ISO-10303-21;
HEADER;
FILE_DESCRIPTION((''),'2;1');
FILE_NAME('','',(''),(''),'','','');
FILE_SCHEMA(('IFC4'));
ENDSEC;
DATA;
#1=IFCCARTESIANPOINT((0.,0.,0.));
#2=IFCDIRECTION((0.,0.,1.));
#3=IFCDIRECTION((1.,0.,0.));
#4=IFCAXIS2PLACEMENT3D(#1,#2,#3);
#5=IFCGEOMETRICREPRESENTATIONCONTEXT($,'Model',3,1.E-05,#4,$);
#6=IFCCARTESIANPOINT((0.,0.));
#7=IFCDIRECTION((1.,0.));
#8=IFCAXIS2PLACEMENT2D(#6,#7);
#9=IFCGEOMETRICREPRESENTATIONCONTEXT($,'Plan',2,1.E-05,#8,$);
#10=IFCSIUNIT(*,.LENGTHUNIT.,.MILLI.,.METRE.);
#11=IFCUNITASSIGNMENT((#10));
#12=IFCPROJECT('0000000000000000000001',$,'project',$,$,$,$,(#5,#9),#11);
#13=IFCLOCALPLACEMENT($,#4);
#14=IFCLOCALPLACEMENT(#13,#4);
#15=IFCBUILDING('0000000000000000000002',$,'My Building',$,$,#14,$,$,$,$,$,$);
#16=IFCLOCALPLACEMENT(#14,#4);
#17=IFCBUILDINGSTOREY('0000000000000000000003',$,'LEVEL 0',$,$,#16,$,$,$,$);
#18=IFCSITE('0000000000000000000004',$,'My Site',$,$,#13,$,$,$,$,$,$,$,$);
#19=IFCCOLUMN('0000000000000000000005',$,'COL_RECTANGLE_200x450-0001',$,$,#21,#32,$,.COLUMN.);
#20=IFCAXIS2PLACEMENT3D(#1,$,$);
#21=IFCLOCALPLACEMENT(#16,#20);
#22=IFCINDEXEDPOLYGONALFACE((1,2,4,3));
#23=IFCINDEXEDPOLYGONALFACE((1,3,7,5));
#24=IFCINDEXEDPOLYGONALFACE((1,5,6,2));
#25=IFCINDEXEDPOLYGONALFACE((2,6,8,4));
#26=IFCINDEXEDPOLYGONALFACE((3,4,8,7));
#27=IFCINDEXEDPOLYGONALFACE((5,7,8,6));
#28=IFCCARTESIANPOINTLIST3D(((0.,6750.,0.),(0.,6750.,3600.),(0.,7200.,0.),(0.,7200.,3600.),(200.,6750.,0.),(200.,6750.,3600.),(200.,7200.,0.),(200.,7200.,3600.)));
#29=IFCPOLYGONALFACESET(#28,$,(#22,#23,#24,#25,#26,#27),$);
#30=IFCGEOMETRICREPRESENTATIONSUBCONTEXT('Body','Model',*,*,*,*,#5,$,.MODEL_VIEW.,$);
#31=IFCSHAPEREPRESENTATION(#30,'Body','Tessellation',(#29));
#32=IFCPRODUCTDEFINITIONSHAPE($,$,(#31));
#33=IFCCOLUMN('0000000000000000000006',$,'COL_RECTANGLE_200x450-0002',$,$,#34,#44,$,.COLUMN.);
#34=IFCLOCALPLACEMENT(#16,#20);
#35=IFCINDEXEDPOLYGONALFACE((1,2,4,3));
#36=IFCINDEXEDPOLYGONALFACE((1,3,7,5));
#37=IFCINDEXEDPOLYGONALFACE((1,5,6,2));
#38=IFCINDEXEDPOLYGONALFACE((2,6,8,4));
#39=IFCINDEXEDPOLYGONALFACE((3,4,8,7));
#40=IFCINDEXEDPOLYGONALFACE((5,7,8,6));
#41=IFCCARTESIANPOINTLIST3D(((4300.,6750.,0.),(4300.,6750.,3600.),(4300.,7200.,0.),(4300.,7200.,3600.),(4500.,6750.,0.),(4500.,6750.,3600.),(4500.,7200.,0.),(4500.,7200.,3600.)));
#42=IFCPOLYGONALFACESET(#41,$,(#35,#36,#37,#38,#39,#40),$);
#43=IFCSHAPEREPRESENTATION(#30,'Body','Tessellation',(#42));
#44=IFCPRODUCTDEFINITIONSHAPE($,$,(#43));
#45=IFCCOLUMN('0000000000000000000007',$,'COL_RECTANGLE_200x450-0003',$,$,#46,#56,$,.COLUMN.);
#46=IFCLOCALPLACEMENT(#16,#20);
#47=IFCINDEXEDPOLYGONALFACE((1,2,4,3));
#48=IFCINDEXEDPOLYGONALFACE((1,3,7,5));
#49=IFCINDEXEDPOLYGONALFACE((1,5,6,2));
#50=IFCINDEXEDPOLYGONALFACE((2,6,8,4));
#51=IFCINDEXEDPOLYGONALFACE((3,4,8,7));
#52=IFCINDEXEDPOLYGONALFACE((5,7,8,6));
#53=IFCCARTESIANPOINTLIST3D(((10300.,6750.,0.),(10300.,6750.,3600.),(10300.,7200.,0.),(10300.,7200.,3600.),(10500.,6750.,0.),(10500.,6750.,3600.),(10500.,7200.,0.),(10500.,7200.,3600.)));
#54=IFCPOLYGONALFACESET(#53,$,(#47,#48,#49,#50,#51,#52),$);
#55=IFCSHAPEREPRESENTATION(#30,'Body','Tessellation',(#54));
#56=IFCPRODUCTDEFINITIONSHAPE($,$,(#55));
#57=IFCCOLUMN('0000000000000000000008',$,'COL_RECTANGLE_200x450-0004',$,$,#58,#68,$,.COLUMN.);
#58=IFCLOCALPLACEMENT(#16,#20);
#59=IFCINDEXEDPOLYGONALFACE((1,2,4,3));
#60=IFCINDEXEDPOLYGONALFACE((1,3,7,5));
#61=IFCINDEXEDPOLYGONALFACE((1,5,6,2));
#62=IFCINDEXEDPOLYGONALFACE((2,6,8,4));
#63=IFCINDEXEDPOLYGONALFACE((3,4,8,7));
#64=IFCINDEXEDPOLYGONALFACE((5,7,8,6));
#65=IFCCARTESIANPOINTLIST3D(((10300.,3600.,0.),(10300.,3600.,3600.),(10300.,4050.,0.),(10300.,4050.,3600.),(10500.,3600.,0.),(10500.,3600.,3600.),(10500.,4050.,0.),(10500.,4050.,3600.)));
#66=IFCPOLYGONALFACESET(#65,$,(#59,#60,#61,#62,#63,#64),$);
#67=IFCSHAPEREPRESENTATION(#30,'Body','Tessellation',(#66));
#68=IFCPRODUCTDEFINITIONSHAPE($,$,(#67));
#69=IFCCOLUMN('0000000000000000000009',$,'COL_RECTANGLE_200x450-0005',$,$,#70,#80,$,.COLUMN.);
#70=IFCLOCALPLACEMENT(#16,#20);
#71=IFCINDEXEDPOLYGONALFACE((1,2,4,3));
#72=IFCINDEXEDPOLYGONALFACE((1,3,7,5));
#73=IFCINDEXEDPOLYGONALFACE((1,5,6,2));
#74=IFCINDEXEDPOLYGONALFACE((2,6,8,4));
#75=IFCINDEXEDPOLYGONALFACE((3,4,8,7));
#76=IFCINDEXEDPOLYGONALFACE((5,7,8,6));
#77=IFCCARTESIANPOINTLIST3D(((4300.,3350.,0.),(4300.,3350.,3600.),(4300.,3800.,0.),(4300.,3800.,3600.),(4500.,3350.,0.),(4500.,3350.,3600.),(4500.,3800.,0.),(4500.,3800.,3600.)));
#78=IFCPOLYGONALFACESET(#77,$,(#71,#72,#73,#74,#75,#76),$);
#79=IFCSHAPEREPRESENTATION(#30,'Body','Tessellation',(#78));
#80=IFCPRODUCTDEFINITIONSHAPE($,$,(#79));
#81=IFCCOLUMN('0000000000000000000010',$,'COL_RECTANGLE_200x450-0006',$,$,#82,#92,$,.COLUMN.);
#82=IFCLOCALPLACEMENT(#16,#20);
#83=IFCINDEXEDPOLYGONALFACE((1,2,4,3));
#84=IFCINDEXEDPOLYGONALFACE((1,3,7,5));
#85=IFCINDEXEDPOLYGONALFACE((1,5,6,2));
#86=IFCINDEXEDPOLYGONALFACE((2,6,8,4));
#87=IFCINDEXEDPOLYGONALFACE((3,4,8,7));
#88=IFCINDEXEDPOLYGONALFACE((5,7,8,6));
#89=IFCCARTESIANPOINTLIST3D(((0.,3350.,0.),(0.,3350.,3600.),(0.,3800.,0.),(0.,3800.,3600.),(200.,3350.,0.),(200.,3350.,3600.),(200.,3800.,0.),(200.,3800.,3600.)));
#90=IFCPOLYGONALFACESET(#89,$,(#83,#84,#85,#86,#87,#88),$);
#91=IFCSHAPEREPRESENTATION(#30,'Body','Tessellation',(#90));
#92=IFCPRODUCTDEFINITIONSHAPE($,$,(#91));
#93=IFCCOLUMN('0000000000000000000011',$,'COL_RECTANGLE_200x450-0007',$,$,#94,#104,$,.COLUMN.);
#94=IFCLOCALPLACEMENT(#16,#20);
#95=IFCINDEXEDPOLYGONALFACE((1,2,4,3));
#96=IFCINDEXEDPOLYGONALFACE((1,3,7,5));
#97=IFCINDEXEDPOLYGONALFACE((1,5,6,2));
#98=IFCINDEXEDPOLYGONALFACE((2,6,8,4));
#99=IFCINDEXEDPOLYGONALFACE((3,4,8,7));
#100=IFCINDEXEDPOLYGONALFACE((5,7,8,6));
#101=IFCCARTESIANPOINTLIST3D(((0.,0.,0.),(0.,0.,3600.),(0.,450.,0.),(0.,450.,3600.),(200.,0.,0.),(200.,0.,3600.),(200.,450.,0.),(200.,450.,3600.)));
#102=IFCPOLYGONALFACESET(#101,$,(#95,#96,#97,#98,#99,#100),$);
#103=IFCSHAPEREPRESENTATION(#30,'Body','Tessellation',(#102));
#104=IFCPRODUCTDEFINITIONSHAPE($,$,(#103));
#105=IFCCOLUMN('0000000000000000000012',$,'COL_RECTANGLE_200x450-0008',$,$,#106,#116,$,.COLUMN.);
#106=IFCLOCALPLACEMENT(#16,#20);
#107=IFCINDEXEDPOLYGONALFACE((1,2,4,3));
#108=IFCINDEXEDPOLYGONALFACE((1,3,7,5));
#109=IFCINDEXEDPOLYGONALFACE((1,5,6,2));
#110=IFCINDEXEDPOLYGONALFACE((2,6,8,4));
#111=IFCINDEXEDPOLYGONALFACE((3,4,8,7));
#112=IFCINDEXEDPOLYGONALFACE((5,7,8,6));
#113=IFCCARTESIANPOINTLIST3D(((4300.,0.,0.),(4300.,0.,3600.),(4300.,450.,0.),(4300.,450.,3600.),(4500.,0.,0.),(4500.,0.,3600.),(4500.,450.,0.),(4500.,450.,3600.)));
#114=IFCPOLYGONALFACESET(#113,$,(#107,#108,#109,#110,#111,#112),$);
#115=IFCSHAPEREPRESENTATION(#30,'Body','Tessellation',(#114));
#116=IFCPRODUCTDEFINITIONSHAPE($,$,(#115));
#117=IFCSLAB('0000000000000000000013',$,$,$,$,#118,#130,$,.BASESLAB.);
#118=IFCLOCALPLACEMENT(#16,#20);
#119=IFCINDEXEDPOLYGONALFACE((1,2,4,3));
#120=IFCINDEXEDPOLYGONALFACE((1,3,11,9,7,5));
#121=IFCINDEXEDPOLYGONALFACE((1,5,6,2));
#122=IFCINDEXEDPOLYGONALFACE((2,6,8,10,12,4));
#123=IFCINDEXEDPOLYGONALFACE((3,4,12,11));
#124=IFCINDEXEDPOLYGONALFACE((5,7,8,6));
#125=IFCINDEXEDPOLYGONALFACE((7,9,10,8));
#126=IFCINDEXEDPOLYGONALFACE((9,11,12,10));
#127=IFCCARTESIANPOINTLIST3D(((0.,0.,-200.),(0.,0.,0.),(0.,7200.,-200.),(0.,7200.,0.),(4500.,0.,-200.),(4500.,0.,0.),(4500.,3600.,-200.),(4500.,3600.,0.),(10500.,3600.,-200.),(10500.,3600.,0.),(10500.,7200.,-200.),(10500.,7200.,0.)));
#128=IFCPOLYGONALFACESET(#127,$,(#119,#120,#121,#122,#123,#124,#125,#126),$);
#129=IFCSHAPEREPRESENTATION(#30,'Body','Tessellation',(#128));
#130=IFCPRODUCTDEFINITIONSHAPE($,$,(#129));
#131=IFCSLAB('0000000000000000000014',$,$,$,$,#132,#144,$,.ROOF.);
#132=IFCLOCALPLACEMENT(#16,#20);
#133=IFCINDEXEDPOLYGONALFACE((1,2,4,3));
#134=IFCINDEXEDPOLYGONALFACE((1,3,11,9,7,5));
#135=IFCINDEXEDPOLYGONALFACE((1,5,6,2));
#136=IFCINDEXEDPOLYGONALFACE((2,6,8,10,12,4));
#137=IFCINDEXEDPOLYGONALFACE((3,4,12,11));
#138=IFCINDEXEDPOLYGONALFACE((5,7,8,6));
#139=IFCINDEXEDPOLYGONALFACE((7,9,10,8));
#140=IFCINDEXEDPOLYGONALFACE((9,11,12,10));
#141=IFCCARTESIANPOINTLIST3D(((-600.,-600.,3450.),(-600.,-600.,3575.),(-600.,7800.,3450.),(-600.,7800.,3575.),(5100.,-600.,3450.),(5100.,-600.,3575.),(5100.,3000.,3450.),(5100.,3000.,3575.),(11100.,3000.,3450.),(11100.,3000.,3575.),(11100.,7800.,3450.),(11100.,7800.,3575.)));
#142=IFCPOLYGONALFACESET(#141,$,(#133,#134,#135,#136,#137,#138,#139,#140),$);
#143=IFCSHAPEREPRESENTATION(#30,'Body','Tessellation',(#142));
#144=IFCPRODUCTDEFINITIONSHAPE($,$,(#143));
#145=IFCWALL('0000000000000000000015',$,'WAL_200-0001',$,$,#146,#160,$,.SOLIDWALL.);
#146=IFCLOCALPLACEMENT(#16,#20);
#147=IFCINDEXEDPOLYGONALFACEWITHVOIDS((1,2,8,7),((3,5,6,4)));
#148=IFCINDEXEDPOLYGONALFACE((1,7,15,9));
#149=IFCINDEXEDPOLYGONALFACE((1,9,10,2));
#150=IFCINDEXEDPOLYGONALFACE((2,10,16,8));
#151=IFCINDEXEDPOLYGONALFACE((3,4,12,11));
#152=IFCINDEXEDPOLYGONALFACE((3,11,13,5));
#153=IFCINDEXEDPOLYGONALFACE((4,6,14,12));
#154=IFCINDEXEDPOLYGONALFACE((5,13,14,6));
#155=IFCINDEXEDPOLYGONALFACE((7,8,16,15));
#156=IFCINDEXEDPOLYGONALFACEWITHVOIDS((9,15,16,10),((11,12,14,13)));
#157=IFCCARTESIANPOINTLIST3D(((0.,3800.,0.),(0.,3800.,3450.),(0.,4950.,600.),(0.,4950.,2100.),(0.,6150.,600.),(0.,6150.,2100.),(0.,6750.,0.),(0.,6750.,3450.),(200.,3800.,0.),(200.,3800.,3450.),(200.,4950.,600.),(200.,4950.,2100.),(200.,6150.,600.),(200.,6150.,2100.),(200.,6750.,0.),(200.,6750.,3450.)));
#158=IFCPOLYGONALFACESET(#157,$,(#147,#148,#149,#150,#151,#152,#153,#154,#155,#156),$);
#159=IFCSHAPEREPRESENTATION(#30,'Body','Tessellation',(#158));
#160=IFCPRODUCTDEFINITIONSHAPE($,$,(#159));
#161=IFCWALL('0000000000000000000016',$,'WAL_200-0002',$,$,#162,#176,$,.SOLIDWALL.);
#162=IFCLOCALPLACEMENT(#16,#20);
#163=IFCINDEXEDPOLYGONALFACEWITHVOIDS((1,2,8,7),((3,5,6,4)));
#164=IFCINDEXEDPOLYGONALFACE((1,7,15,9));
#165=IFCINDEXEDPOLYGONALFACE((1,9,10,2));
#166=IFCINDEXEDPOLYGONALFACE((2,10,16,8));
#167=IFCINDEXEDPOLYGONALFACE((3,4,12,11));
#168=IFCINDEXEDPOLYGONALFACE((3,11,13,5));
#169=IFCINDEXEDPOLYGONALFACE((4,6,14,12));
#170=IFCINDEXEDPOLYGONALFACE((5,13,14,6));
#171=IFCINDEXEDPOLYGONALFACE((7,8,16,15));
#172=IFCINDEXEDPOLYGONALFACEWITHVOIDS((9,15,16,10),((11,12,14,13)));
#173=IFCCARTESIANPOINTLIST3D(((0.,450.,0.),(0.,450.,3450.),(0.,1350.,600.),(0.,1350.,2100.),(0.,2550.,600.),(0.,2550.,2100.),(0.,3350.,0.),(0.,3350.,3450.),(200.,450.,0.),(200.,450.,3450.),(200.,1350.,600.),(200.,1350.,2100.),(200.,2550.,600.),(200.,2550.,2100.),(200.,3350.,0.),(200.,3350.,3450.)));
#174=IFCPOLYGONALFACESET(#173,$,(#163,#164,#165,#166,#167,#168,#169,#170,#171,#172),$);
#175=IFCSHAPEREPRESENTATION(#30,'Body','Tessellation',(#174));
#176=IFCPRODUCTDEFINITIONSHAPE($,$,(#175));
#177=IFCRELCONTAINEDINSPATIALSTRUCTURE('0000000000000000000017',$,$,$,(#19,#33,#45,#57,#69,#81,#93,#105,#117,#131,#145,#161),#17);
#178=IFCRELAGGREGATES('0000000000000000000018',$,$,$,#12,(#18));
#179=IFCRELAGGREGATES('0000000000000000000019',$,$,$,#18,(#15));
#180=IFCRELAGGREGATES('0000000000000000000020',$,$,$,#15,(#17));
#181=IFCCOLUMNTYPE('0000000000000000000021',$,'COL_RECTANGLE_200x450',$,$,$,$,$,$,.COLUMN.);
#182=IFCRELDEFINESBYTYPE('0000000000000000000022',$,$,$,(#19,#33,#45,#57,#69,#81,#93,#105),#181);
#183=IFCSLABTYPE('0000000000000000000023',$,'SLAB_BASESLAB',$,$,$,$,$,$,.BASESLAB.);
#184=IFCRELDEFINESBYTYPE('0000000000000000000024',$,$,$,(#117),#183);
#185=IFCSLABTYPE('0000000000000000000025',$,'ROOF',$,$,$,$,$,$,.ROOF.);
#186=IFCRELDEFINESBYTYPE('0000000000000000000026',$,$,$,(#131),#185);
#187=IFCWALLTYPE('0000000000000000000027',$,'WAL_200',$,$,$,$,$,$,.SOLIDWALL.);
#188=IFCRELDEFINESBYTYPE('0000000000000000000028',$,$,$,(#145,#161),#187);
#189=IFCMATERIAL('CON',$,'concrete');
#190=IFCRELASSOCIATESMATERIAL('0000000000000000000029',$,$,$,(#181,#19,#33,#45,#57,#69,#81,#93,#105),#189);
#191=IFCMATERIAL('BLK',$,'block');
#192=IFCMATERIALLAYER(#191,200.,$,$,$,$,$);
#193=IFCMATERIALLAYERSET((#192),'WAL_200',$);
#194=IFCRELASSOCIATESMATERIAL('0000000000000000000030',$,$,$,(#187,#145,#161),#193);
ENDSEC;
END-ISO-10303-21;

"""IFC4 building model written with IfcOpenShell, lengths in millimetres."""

from ifc_helpers import new_model, si_unit, frame, origin_with_axes, origin_2d_with_axis, place, context, subcontext, project, spatial, indexed_curve, rectangle, outline, extrude, material, layer, layer_set, layer_usage, material_profile, profile_set, profile_usage, type_object, element, save


model = new_model("IFC4")

# Units and contexts
model_context = context("Model", 3, precision=1e-05, world=origin_with_axes())
plan_context = context("Plan", 2, precision=1e-05, world=origin_2d_with_axis())
body_context = subcontext(model_context, "Body", "Model", "MODEL_VIEW")
ifc_project = project(units=[si_unit("LENGTHUNIT", "METRE", prefix="MILLI")], contexts=[model_context, plan_context])

# Site, building, storey
site_placement = place(None, origin_with_axes())
site = spatial("IfcSite", under=ifc_project, at=site_placement, Name="My Site")
building_placement = place(site_placement, origin_with_axes())
building = spatial("IfcBuilding", under=site, at=building_placement, Name="My Building")
storey_placement = place(building_placement, origin_with_axes())
storey = spatial("IfcBuildingStorey", under=building, at=storey_placement, Name="LEVEL 0")

# Columns
ifc_material_1 = material(Name="CON", Category="concrete")
ifc_material_profile = material_profile(ifc_material_1, rectangle(XDim=200.0, YDim=450.0))
ifc_profile_set = profile_set([ifc_material_profile], Name="COL_RECTANGLE_200x450")
ifc_profile_usage_1 = profile_usage(ifc_profile_set)
column_type = type_object("IfcColumnType", Name="COL_RECTANGLE_200x450", PredefinedType="COLUMN", material=ifc_profile_set)
column_1_placement = place(storey_placement, frame((100.0, 6975.0, 0.0), z_axis=(0.0, 0.0, 1.0), x_axis=(1.0, 0.0, 0.0)))
element("IfcColumn", 1, at=column_1_placement, inside=storey, type_object=column_type, material=ifc_profile_usage_1, Name="COL_RECTANGLE_200x450-0001", PredefinedType="COLUMN", context=body_context, shape_type="SweptSolid", body=[
    extrude(rectangle(XDim=200.0, YDim=450.0), origin_with_axes(), (0.0, 0.0, 1.0), 3600.0),
])
ifc_profile_usage_2 = profile_usage(ifc_profile_set)
column_2_placement = place(storey_placement, frame((4400.0, 6975.0, 0.0), z_axis=(0.0, 0.0, 1.0), x_axis=(1.0, 0.0, 0.0)))
element("IfcColumn", 2, at=column_2_placement, inside=storey, type_object=column_type, material=ifc_profile_usage_2, Name="COL_RECTANGLE_200x450-0002", PredefinedType="COLUMN", context=body_context, shape_type="SweptSolid", body=[
    extrude(rectangle(XDim=200.0, YDim=450.0), origin_with_axes(), (0.0, 0.0, 1.0), 3600.0),
])
ifc_profile_usage_3 = profile_usage(ifc_profile_set)
column_3_placement = place(storey_placement, frame((10400.0, 6975.0, 0.0), z_axis=(0.0, 0.0, 1.0), x_axis=(1.0, 0.0, 0.0)))
element("IfcColumn", 3, at=column_3_placement, inside=storey, type_object=column_type, material=ifc_profile_usage_3, Name="COL_RECTANGLE_200x450-0003", PredefinedType="COLUMN", context=body_context, shape_type="SweptSolid", body=[
    extrude(rectangle(XDim=200.0, YDim=450.0), origin_with_axes(), (0.0, 0.0, 1.0), 3600.0),
])
ifc_profile_usage_4 = profile_usage(ifc_profile_set)
column_4_placement = place(storey_placement, frame((10400.0, 3825.0, 0.0), z_axis=(0.0, 0.0, 1.0), x_axis=(1.0, 0.0, 0.0)))
element("IfcColumn", 4, at=column_4_placement, inside=storey, type_object=column_type, material=ifc_profile_usage_4, Name="COL_RECTANGLE_200x450-0004", PredefinedType="COLUMN", context=body_context, shape_type="SweptSolid", body=[
    extrude(rectangle(XDim=200.0, YDim=450.0), origin_with_axes(), (0.0, 0.0, 1.0), 3600.0),
])
ifc_profile_usage_5 = profile_usage(ifc_profile_set)
column_5_placement = place(storey_placement, frame((4400.0, 3575.0, 0.0), z_axis=(0.0, 0.0, 1.0), x_axis=(1.0, 0.0, 0.0)))
element("IfcColumn", 5, at=column_5_placement, inside=storey, type_object=column_type, material=ifc_profile_usage_5, Name="COL_RECTANGLE_200x450-0005", PredefinedType="COLUMN", context=body_context, shape_type="SweptSolid", body=[
    extrude(rectangle(XDim=200.0, YDim=450.0), origin_with_axes(), (0.0, 0.0, 1.0), 3600.0),
])
ifc_profile_usage_6 = profile_usage(ifc_profile_set)
column_6_placement = place(storey_placement, frame((100.0, 3575.0, 0.0), z_axis=(0.0, 0.0, 1.0), x_axis=(1.0, 0.0, 0.0)))
element("IfcColumn", 6, at=column_6_placement, inside=storey, type_object=column_type, material=ifc_profile_usage_6, Name="COL_RECTANGLE_200x450-0006", PredefinedType="COLUMN", context=body_context, shape_type="SweptSolid", body=[
    extrude(rectangle(XDim=200.0, YDim=450.0), origin_with_axes(), (0.0, 0.0, 1.0), 3600.0),
])
ifc_profile_usage_7 = profile_usage(ifc_profile_set)
column_7_placement = place(storey_placement, frame((100.0, 225.0, 0.0), z_axis=(0.0, 0.0, 1.0), x_axis=(1.0, 0.0, 0.0)))
element("IfcColumn", 7, at=column_7_placement, inside=storey, type_object=column_type, material=ifc_profile_usage_7, Name="COL_RECTANGLE_200x450-0007", PredefinedType="COLUMN", context=body_context, shape_type="SweptSolid", body=[
    extrude(rectangle(XDim=200.0, YDim=450.0), origin_with_axes(), (0.0, 0.0, 1.0), 3600.0),
])
ifc_profile_usage_8 = profile_usage(ifc_profile_set)
column_8_placement = place(storey_placement, frame((4400.0, 225.0, 0.0), z_axis=(0.0, 0.0, 1.0), x_axis=(1.0, 0.0, 0.0)))
element("IfcColumn", 8, at=column_8_placement, inside=storey, type_object=column_type, material=ifc_profile_usage_8, Name="COL_RECTANGLE_200x450-0008", PredefinedType="COLUMN", context=body_context, shape_type="SweptSolid", body=[
    extrude(rectangle(XDim=200.0, YDim=450.0), origin_with_axes(), (0.0, 0.0, 1.0), 3600.0),
])

# Slabs
slab_type_1 = type_object("IfcSlabType", Name="SLAB_BASESLAB", PredefinedType="BASESLAB")
slab_1_placement = place(storey_placement, frame((0.0, 0.0, -200.0), z_axis=(0.0, 0.0, 1.0), x_axis=(1.0, 0.0, 0.0)))
element("IfcSlab", 9, at=slab_1_placement, inside=storey, type_object=slab_type_1, PredefinedType="BASESLAB", context=body_context, shape_type="SweptSolid", body=[
    extrude(outline(indexed_curve([(0.0, 0.0), (4500.0, 0.0), (4500.0, 3600.0), (10500.0, 3600.0), (10500.0, 7200.0), (0.0, 7200.0), (0.0, 0.0), (0.0, 0.0)])), None, (0.0, 0.0, 1.0), 200.0),
])
slab_type_2 = type_object("IfcSlabType", Name="ROOF", PredefinedType="ROOF")
slab_2_placement = place(storey_placement, frame((0.0, 0.0, 3450.0), z_axis=(0.0, 0.0, 1.0), x_axis=(1.0, 0.0, 0.0)))
element("IfcSlab", 10, at=slab_2_placement, inside=storey, type_object=slab_type_2, PredefinedType="ROOF", context=body_context, shape_type="SweptSolid", body=[
    extrude(outline(indexed_curve([(-600.0, -600.0), (5100.0, -600.0), (5100.0, 3000.0), (11100.0, 3000.0), (11100.0, 7800.0), (-600.0, 7800.0), (-600.0, -600.0)])), None, (0.0, 0.0, 1.0), 125.0),
])

# Walls, openings
ifc_material_2 = material(Name="BLK", Category="block")
ifc_layer_1 = layer(ifc_material_2, 200.0)
ifc_layer_set_1 = layer_set([ifc_layer_1], Name="WAL_200")
ifc_layer_usage_1 = layer_usage(ifc_layer_set_1, "AXIS2", "POSITIVE", 0.0)
wall_type_1 = type_object("IfcWallType", Name="WAL_200", PredefinedType="SOLIDWALL", material=ifc_layer_set_1)
wall_1_placement = place(storey_placement, frame((200.0, 3800.0, 0.0), z_axis=(0.0, 0.0, 1.0), x_axis=(0.0, 1.0, 0.0)))
wall_1 = element("IfcWall", 11, at=wall_1_placement, inside=storey, type_object=wall_type_1, material=ifc_layer_usage_1, Name="WAL_200-0001", PredefinedType="SOLIDWALL", context=body_context, shape_type="SweptSolid", body=[
    extrude(outline(indexed_curve([(0.0, 0.0), (0.0, 200.0), (2950.0, 200.0), (2950.0, 0.0), (0.0, 0.0)], self_intersect=False)), origin_with_axes(), (0.0, 0.0, 1.0), 3450.0),
])
opening_1_placement = place(wall_1_placement, frame((1150.0, 0.0, 600.0), z_axis=(0.0, 0.0, 1.0), x_axis=(1.0, 0.0, 0.0)))
element("IfcOpeningElement", 12, at=opening_1_placement, cuts=wall_1, PredefinedType="OPENING", context=body_context, shape_type="SweptSolid", body=[
    extrude(outline(indexed_curve([(0.0, 0.0), (0.0, 400.0), (1200.0, 400.0), (1200.0, 0.0), (0.0, 0.0)], self_intersect=False)), frame((0.0, -100.0, 0.0), z_axis=(0.0, 0.0, 1.0), x_axis=(1.0, 0.0, 0.0)), (0.0, 0.0, 1.0), 1500.0),
])
ifc_layer_usage_2 = layer_usage(ifc_layer_set_1, "AXIS2", "POSITIVE", 0.0)
wall_2_placement = place(storey_placement, frame((200.0, 450.0, 0.0), z_axis=(0.0, 0.0, 1.0), x_axis=(0.0, 1.0, 0.0)))
wall_2 = element("IfcWall", 13, at=wall_2_placement, inside=storey, type_object=wall_type_1, material=ifc_layer_usage_2, Name="WAL_200-0002", PredefinedType="SOLIDWALL", context=body_context, shape_type="SweptSolid", body=[
    extrude(outline(indexed_curve([(0.0, 0.0), (0.0, 200.0), (2900.0, 200.0), (2900.0, 0.0), (0.0, 0.0)], self_intersect=False)), origin_with_axes(), (0.0, 0.0, 1.0), 3450.0),
])
opening_2_placement = place(wall_2_placement, frame((900.0, 0.0, 600.0), z_axis=(0.0, 0.0, 1.0), x_axis=(1.0, 0.0, 0.0)))
element("IfcOpeningElement", 14, at=opening_2_placement, cuts=wall_2, PredefinedType="OPENING", context=body_context, shape_type="SweptSolid", body=[
    extrude(outline(indexed_curve([(0.0, 0.0), (0.0, 400.0), (1200.0, 400.0), (1200.0, 0.0), (0.0, 0.0)], self_intersect=False)), frame((0.0, -100.0, 0.0), z_axis=(0.0, 0.0, 1.0), x_axis=(1.0, 0.0, 0.0)), (0.0, 0.0, 1.0), 1500.0),
])

save(model, "model.ifc")
